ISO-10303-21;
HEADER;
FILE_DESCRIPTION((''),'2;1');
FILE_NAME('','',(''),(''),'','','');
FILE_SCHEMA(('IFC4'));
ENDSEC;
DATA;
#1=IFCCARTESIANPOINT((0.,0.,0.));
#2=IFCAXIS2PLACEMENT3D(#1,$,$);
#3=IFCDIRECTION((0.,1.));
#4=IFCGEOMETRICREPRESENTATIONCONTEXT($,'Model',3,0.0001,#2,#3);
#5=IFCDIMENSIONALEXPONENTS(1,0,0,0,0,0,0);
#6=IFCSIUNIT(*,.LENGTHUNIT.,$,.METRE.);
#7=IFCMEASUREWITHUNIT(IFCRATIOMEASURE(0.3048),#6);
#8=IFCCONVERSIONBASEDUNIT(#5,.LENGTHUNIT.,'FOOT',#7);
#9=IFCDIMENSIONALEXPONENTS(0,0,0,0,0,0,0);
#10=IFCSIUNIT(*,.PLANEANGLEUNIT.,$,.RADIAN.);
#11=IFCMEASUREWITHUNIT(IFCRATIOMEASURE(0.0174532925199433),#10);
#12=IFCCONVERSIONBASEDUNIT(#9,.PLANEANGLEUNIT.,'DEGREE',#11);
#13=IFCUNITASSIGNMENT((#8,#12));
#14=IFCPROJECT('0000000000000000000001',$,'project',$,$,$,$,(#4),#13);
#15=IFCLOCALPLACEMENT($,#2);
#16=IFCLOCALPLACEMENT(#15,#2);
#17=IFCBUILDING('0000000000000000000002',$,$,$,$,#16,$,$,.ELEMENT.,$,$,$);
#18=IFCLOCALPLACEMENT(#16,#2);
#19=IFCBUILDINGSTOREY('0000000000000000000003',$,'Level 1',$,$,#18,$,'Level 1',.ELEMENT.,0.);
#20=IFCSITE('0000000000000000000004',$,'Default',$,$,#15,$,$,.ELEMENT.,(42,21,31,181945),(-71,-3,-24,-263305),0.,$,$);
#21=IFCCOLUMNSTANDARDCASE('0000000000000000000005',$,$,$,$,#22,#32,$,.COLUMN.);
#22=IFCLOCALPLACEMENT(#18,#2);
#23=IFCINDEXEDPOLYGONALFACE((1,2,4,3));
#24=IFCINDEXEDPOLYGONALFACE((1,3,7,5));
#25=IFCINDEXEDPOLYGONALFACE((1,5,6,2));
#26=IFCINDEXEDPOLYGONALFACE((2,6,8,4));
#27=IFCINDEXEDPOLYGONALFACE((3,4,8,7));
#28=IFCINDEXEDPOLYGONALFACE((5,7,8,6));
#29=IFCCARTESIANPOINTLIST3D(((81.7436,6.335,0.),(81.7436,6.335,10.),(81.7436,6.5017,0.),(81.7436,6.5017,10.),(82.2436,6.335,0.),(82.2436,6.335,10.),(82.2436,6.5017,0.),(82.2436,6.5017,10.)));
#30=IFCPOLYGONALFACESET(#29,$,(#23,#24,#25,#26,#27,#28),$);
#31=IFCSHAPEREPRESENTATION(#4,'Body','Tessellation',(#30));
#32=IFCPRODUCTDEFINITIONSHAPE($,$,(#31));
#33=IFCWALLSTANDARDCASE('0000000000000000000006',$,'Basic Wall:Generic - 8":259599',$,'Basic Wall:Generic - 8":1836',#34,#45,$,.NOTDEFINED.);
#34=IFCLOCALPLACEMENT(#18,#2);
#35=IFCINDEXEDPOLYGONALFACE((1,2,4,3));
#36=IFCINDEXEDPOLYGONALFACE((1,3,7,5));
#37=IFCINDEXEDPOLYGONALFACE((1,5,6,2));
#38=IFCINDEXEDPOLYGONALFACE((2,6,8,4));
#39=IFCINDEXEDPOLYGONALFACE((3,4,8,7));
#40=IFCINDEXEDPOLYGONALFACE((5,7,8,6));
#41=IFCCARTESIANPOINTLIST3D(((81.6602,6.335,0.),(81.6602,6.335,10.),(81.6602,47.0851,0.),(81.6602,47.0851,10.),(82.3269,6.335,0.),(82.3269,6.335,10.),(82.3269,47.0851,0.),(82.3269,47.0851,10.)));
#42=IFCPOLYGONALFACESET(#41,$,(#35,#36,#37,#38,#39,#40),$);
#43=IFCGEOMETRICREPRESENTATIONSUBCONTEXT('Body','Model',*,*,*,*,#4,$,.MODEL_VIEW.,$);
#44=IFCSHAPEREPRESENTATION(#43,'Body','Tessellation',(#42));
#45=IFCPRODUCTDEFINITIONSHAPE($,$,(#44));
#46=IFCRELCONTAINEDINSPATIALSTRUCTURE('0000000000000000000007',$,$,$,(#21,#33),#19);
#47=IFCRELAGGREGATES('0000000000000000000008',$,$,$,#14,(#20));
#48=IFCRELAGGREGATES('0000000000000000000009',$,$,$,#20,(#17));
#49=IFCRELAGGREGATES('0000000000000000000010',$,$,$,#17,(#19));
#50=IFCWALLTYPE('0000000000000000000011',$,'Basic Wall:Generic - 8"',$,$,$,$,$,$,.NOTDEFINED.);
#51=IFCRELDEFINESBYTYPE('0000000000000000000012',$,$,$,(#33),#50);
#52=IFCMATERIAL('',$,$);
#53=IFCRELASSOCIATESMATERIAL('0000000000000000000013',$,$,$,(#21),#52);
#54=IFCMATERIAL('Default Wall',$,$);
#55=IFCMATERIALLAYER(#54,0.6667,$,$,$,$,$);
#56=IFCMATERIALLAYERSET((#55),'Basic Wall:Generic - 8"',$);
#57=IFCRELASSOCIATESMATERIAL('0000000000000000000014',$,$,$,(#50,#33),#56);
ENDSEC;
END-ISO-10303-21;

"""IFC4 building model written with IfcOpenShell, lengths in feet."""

from ifc_helpers import new_model, entity, si_unit, converted_unit, direction, frame, frame_2d, origin, place, context, subcontext, project, spatial, rectangle, extrude, material, layer, layer_set, layer_usage, type_object, element, save


model = new_model("IFC4")

# Units and contexts
model_context = context("Model", 3, precision=0.0001, world=origin(), true_north=direction((0.0, 1.0)))
body_context = subcontext(model_context, "Body", "Model", "MODEL_VIEW")
ifc_project = project(units=[converted_unit("LENGTHUNIT", "FOOT", entity("IfcRatioMeasure", 0.3048), si_unit("LENGTHUNIT", "METRE"), dimensions=[1, 0, 0, 0, 0, 0, 0]), converted_unit("PLANEANGLEUNIT", "DEGREE", entity("IfcRatioMeasure", 0.0174532925199433), si_unit("PLANEANGLEUNIT", "RADIAN"), dimensions=[0, 0, 0, 0, 0, 0, 0])], contexts=[model_context])

# Site, building, storey
site_placement = place(None, origin())
site = spatial("IfcSite", under=ifc_project, at=site_placement, Name="Default", CompositionType="ELEMENT", RefLatitude=(42, 21, 31, 181945), RefLongitude=(-71, -3, -24, -263305), RefElevation=0.0)
building_placement = place(site_placement, origin())
building = spatial("IfcBuilding", under=site, at=building_placement, CompositionType="ELEMENT")
storey_placement = place(building_placement, origin())
storey = spatial("IfcBuildingStorey", under=building, at=storey_placement, Name="Level 1", LongName="Level 1", CompositionType="ELEMENT", Elevation=0.0)

# Column
ifc_material_1 = material(Name="")
wall_placement = place(storey_placement, frame((81.9936, 6.335, 0.0), z_axis=(0.0, 0.0, 1.0), x_axis=(0.0, 1.0, 0.0)))
for number, where, z_axis, x_axis in (
    (1, (0.0833, 0.0, 0.0), (0.0, 0.0, 1.0), (1.0, 0.0, 0.0)),
):
    element("IfcColumnStandardCase", number, at=place(wall_placement, frame(where, z_axis=z_axis, x_axis=x_axis)), inside=storey, material=ifc_material_1, PredefinedType="COLUMN", context=model_context, shape_type="SweptSolid", body=[
        extrude(rectangle(XDim=0.1667, YDim=0.5), origin(), (0.0, 0.0, 1.0), 10.0),
    ])

# Wall
ifc_material_2 = material(Name="Default Wall")
ifc_layer = layer(ifc_material_2, 0.6667)
ifc_layer_set = layer_set([ifc_layer], Name="Basic Wall:Generic - 8\"")
ifc_layer_usage = layer_usage(ifc_layer_set, "AXIS2", "NEGATIVE", 0.3333)
wall_type = type_object("IfcWallType", Name="Basic Wall:Generic - 8\"", PredefinedType="NOTDEFINED", material=ifc_layer_set)
element("IfcWallStandardCase", 2, at=wall_placement, inside=storey, type_object=wall_type, material=ifc_layer_usage, Name="Basic Wall:Generic - 8\":259599", ObjectType="Basic Wall:Generic - 8\":1836", PredefinedType="NOTDEFINED", context=body_context, shape_type="SweptSolid", body=[
    extrude(rectangle(XDim=40.7501, YDim=0.6667, at=frame_2d((20.375, 0.0), x_axis=(-1.0, 0.0))), origin(), (0.0, 0.0, 1.0), 10.0),
])

save(model, "model.ifc")
